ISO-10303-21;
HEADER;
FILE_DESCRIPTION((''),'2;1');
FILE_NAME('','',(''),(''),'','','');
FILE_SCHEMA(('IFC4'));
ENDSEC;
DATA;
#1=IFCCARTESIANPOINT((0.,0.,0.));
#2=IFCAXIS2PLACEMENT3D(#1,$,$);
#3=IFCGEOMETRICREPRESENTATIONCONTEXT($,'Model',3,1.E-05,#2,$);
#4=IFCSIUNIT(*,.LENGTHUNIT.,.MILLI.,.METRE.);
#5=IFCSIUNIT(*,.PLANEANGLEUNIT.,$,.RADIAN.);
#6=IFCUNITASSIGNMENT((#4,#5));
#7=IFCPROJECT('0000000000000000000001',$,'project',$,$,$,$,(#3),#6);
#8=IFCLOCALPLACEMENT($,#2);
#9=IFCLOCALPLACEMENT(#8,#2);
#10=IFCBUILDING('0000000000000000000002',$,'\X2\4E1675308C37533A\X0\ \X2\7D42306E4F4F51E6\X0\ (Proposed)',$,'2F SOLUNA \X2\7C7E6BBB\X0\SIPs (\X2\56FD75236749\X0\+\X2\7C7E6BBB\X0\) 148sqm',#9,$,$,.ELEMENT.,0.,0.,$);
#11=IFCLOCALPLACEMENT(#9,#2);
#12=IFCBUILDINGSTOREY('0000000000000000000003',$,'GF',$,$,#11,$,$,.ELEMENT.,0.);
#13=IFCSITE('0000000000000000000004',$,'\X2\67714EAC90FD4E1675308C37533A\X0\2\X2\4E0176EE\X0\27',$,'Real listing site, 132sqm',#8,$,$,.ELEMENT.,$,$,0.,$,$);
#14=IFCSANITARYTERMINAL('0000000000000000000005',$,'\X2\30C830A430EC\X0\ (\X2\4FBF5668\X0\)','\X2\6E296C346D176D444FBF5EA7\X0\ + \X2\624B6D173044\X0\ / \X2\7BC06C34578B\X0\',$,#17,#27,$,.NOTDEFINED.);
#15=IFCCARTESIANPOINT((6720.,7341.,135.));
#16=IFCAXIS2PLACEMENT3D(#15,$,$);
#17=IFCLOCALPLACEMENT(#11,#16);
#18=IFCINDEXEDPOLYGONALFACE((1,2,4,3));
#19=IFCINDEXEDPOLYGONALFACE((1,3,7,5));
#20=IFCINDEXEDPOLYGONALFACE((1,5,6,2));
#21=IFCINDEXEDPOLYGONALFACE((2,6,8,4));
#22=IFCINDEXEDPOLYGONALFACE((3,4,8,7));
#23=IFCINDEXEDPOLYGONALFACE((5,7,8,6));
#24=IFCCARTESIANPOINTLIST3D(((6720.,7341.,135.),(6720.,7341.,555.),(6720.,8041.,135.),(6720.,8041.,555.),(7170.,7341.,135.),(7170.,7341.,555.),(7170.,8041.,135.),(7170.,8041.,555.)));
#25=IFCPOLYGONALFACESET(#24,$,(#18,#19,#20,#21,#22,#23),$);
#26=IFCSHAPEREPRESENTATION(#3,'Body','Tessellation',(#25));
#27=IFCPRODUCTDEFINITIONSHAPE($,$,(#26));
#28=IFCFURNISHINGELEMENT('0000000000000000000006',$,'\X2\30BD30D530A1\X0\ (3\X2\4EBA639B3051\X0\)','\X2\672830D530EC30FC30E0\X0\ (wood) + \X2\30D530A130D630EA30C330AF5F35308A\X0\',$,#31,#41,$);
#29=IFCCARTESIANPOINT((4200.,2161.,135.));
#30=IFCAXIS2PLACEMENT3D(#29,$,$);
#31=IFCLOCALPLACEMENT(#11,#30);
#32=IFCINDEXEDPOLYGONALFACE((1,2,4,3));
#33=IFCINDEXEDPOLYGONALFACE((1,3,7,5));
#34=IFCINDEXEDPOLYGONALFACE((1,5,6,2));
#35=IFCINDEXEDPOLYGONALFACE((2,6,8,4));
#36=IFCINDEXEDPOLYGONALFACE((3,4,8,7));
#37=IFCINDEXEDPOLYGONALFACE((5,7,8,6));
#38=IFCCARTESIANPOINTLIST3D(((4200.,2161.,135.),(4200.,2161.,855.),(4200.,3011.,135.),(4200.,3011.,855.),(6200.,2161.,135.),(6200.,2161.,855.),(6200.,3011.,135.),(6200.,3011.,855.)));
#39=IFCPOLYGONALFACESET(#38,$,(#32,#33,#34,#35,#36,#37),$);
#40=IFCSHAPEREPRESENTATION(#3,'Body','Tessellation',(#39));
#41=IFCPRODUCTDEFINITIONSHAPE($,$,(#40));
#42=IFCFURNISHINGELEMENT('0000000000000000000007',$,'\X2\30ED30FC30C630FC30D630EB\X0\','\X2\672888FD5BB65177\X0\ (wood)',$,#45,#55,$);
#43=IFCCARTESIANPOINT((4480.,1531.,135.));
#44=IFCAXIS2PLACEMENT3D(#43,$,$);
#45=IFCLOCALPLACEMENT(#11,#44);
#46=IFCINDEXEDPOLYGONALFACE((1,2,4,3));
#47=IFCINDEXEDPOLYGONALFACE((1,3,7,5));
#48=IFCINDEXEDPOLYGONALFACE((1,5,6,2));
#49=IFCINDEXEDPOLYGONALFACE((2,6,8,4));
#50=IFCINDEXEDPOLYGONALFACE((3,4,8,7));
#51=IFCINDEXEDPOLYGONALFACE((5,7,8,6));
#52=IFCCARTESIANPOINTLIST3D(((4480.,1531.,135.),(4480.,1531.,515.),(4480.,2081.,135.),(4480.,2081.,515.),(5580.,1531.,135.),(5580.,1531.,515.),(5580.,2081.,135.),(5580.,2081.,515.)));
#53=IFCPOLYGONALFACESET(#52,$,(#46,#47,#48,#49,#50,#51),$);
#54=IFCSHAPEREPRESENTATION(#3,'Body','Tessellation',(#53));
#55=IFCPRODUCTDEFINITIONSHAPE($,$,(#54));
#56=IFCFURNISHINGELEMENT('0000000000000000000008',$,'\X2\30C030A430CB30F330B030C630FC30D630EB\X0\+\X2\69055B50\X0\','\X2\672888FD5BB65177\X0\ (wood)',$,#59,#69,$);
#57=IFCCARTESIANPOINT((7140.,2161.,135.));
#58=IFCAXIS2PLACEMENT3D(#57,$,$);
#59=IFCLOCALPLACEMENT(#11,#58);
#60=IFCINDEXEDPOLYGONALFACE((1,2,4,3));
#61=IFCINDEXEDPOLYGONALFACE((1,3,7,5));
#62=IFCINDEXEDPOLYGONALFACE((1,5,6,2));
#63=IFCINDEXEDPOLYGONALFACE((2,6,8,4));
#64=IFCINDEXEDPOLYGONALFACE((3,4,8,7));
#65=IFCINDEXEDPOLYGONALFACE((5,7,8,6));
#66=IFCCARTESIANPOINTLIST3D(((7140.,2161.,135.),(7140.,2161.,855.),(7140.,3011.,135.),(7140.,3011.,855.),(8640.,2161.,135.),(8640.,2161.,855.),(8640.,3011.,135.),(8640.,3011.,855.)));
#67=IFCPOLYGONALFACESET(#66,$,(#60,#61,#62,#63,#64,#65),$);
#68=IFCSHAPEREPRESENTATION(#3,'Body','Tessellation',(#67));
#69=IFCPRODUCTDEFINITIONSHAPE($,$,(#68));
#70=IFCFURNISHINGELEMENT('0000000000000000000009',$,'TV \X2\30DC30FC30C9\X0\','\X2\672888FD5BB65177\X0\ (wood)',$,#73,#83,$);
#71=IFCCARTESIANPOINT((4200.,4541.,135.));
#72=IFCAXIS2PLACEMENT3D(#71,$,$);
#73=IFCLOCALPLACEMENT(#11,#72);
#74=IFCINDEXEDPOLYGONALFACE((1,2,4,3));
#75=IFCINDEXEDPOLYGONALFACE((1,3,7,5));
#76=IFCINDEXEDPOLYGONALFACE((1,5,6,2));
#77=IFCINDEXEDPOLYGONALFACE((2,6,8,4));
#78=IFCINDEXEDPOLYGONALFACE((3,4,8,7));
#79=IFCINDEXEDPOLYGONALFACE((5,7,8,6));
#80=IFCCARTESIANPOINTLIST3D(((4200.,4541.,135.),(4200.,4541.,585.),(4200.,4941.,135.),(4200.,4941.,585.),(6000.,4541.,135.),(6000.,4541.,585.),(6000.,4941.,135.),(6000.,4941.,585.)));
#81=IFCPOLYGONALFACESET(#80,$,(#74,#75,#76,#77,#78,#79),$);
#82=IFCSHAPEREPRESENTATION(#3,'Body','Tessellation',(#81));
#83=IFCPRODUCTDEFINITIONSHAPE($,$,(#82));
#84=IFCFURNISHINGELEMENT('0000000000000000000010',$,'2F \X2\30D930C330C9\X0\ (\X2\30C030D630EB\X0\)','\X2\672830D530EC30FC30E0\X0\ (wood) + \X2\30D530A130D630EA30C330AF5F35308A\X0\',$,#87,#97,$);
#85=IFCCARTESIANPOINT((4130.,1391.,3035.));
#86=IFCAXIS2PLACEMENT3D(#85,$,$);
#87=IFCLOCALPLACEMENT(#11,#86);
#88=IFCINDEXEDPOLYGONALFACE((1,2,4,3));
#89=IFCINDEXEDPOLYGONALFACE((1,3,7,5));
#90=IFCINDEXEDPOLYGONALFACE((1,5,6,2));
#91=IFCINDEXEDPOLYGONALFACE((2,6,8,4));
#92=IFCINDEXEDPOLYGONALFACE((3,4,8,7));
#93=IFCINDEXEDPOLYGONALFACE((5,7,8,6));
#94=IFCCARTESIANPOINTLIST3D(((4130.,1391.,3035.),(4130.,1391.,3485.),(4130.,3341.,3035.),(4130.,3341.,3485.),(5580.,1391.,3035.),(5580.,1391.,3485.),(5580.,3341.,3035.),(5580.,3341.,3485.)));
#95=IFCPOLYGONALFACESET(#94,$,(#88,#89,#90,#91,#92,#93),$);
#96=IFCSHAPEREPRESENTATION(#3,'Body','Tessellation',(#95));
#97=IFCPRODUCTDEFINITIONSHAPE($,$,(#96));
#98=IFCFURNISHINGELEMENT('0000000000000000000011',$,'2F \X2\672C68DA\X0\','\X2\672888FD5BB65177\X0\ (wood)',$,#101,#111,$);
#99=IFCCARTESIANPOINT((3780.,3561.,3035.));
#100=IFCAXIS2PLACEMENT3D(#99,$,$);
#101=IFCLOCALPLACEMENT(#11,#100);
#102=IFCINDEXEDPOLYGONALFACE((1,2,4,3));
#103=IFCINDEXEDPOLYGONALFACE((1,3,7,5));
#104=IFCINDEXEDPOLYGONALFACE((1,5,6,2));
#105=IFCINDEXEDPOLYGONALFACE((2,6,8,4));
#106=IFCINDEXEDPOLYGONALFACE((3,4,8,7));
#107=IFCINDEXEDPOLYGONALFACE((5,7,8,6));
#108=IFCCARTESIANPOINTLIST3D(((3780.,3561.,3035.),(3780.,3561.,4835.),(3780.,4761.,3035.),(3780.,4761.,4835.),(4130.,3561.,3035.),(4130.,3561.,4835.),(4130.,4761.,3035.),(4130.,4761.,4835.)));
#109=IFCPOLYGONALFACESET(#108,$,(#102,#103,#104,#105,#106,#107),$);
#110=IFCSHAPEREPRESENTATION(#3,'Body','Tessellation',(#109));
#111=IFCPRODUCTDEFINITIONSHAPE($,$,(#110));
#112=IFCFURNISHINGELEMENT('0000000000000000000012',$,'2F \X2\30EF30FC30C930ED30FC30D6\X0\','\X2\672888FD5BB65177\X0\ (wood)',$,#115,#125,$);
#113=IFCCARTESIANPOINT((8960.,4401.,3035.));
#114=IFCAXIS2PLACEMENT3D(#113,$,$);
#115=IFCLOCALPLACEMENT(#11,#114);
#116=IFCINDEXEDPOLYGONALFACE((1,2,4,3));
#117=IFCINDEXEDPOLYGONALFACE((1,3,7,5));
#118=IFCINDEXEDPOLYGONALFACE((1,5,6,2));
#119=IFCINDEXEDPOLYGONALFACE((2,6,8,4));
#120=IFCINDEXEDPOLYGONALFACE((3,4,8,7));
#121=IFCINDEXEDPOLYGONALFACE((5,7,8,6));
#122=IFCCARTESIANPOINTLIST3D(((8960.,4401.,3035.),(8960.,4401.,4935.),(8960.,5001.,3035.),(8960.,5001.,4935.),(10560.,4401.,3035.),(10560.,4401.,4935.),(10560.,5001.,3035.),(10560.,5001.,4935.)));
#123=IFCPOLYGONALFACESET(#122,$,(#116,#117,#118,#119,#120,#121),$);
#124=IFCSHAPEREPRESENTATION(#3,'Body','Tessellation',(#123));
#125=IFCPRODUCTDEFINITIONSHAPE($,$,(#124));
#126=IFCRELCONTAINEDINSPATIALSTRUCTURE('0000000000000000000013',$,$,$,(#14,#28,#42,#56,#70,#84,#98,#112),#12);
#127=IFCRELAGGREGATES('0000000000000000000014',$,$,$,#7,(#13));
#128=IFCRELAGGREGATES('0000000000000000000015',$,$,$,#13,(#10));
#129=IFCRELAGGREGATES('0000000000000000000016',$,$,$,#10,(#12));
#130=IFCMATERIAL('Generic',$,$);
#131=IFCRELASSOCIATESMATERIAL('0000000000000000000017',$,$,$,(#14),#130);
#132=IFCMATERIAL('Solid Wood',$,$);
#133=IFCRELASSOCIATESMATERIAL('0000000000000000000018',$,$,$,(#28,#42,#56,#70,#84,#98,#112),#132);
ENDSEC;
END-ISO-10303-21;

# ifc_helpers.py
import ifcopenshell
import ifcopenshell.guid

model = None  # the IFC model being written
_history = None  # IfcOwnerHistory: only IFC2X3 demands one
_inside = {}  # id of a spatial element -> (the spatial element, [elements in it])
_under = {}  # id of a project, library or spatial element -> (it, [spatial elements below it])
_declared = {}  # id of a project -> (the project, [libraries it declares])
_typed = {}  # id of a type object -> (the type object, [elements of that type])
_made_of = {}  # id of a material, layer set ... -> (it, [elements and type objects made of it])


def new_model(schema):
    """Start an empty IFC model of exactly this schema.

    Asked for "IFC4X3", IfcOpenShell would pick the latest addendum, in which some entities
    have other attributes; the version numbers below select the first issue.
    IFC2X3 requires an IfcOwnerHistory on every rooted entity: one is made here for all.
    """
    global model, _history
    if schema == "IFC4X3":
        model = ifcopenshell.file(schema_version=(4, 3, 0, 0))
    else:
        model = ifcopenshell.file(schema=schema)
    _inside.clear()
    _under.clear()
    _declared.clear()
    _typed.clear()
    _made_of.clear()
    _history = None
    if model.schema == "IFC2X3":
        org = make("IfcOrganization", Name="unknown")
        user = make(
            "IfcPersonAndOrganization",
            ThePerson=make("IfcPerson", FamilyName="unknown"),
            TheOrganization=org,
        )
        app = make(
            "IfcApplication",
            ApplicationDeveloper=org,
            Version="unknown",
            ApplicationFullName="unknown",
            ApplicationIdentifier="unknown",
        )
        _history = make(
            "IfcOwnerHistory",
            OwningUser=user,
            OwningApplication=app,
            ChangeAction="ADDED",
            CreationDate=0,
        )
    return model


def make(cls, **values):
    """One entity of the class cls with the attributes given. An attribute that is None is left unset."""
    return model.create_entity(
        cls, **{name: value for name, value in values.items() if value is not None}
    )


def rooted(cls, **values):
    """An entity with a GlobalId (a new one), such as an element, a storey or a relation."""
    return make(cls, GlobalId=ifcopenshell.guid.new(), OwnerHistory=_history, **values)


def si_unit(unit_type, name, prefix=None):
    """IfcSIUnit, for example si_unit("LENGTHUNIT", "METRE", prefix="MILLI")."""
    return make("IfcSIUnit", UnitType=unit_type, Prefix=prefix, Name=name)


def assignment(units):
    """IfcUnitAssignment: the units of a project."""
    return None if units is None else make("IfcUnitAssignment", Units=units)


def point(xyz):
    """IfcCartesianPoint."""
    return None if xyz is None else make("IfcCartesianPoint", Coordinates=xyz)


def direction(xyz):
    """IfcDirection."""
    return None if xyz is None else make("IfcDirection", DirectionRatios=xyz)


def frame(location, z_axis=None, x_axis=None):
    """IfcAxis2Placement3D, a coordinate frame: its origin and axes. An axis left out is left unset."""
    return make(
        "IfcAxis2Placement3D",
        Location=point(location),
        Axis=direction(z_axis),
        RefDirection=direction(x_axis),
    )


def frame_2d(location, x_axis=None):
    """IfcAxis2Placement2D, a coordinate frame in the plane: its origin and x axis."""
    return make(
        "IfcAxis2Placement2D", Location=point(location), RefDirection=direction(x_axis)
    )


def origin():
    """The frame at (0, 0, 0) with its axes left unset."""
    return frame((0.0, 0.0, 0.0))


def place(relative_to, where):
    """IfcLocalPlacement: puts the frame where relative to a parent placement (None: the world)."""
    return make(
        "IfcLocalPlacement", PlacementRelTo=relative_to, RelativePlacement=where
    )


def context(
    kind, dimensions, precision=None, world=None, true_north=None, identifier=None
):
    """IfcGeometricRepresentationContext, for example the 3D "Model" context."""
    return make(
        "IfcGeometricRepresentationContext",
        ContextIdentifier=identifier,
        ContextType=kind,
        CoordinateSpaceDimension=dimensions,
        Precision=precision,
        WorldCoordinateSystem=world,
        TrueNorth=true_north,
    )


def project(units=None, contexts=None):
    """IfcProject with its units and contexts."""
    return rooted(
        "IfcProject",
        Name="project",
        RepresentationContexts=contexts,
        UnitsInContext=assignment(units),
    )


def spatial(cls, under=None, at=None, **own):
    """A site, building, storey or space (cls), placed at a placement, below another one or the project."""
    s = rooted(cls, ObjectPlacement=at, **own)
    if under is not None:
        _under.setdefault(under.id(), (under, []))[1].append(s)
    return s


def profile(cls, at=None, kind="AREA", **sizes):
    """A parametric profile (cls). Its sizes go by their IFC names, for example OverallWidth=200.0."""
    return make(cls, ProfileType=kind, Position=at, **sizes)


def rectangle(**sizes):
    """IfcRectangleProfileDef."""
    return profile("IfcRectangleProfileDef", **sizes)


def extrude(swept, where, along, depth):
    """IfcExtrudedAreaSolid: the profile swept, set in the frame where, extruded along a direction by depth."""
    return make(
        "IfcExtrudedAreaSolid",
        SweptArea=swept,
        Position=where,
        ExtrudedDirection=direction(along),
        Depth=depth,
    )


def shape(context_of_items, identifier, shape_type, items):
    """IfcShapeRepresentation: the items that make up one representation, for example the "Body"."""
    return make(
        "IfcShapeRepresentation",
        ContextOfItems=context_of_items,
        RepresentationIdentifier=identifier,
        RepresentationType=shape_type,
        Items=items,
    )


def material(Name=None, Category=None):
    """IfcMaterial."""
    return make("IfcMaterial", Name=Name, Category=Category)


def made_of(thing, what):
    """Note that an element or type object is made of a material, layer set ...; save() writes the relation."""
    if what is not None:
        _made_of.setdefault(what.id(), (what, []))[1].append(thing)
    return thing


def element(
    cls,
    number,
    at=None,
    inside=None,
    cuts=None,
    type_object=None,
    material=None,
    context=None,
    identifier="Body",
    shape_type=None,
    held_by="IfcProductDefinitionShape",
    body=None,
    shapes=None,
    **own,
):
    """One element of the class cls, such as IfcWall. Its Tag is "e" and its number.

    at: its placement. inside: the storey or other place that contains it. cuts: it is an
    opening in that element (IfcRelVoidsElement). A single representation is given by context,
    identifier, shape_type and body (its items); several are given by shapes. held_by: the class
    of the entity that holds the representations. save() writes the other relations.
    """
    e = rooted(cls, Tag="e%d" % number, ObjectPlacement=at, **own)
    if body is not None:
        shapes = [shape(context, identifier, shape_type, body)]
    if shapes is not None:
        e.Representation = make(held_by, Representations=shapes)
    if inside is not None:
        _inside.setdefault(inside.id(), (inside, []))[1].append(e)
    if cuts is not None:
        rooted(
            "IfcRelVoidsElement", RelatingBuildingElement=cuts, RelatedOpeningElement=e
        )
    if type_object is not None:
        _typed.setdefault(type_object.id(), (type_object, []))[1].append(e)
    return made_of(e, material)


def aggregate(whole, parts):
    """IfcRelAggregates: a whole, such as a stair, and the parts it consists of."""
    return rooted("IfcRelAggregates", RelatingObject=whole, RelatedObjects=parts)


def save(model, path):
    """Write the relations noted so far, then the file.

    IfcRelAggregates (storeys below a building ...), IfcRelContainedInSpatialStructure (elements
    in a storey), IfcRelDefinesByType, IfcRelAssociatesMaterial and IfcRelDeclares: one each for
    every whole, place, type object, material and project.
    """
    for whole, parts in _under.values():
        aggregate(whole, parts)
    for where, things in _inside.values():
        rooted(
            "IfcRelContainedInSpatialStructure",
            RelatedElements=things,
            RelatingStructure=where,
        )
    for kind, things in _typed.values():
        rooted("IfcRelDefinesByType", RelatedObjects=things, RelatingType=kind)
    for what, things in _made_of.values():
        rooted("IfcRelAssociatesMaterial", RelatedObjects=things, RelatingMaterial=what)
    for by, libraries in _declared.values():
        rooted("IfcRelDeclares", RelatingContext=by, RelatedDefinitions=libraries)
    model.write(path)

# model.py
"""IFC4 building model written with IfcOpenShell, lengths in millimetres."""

from ifc_helpers import new_model, si_unit, frame, frame_2d, origin, place, context, project, spatial, rectangle, extrude, material, element, save


model = new_model("IFC4")

# Units and contexts
model_context = context("Model", 3, precision=1e-05, world=origin())
ifc_project = project(units=[si_unit("LENGTHUNIT", "METRE", prefix="MILLI"), si_unit("PLANEANGLEUNIT", "RADIAN")], contexts=[model_context])

# Site, building, storey
site_placement = place(None, origin())
site = spatial("IfcSite", under=ifc_project, at=site_placement, Name="東京都世田谷区2丁目27", ObjectType="Real listing site, 132sqm", CompositionType="ELEMENT", RefElevation=0.0)
building_placement = place(site_placement, origin())
building = spatial("IfcBuilding", under=site, at=building_placement, Name="世田谷区 終の住処 (Proposed)", ObjectType="2F SOLUNA 籾殻SIPs (国産杉+籾殻) 148sqm", CompositionType="ELEMENT", ElevationOfRefHeight=0.0, ElevationOfTerrain=0.0)
storey_placement = place(building_placement, origin())
storey = spatial("IfcBuildingStorey", under=building, at=storey_placement, Name="GF", CompositionType="ELEMENT", Elevation=0.0)

# Shared definitions
ifc_material_1 = material(Name="Solid Wood")

# Shared definitions
ifc_material_2 = material(Name="Generic")

# Sanitary terminal
sanitary_terminal_1_placement = place(storey_placement, frame((6720.0, 7341.0, 135.0)))
element("IfcSanitaryTerminal", 1, at=sanitary_terminal_1_placement, inside=storey, material=ifc_material_2, Name="トイレ (便器)", Description="温水洗浄便座 + 手洗い / 節水型", PredefinedType="NOTDEFINED", context=model_context, shape_type="SweptSolid", body=[
    extrude(rectangle(XDim=450.0, YDim=700.0, at=frame_2d((225.0, 350.0))), frame((6720.0, 7341.0, 135.0)), (0.0, 0.0, 1.0), 420.0),
])

# Furnishing elements
furnishing_1_placement = place(storey_placement, frame((4200.0, 2161.0, 135.0)))
element("IfcFurnishingElement", 2, at=furnishing_1_placement, inside=storey, material=ifc_material_1, Name="ソファ (3人掛け)", Description="木フレーム (wood) + ファブリック張り", context=model_context, shape_type="SweptSolid", body=[
    extrude(rectangle(XDim=2000.0, YDim=850.0, at=frame_2d((1000.0, 425.0))), frame((4200.0, 2161.0, 135.0)), (0.0, 0.0, 1.0), 720.0),
])
furnishing_2_placement = place(storey_placement, frame((4480.0, 1531.0, 135.0)))
element("IfcFurnishingElement", 3, at=furnishing_2_placement, inside=storey, material=ifc_material_1, Name="ローテーブル", Description="木製家具 (wood)", context=model_context, shape_type="SweptSolid", body=[
    extrude(rectangle(XDim=1100.0, YDim=550.0, at=frame_2d((550.0, 275.0))), frame((4480.0, 1531.0, 135.0)), (0.0, 0.0, 1.0), 380.0),
])
furnishing_3_placement = place(storey_placement, frame((7140.0, 2161.0, 135.0)))
element("IfcFurnishingElement", 4, at=furnishing_3_placement, inside=storey, material=ifc_material_1, Name="ダイニングテーブル+椅子", Description="木製家具 (wood)", context=model_context, shape_type="SweptSolid", body=[
    extrude(rectangle(XDim=1500.0, YDim=850.0, at=frame_2d((750.0, 425.0))), frame((7140.0, 2161.0, 135.0)), (0.0, 0.0, 1.0), 720.0),
])
furnishing_4_placement = place(storey_placement, frame((4200.0, 4541.0, 135.0)))
element("IfcFurnishingElement", 5, at=furnishing_4_placement, inside=storey, material=ifc_material_1, Name="TV ボード", Description="木製家具 (wood)", context=model_context, shape_type="SweptSolid", body=[
    extrude(rectangle(XDim=1800.0, YDim=400.0, at=frame_2d((900.0, 200.0))), frame((4200.0, 4541.0, 135.0)), (0.0, 0.0, 1.0), 450.0),
])
furnishing_5_placement = place(storey_placement, frame((4130.0, 1391.0, 3035.0)))
element("IfcFurnishingElement", 6, at=furnishing_5_placement, inside=storey, material=ifc_material_1, Name="2F ベッド (ダブル)", Description="木フレーム (wood) + ファブリック張り", context=model_context, shape_type="SweptSolid", body=[
    extrude(rectangle(XDim=1450.0, YDim=1950.0, at=frame_2d((725.0, 975.0))), frame((4130.0, 1391.0, 3035.0)), (0.0, 0.0, 1.0), 450.0),
])
furnishing_6_placement = place(storey_placement, frame((3780.0, 3561.0, 3035.0)))
element("IfcFurnishingElement", 7, at=furnishing_6_placement, inside=storey, material=ifc_material_1, Name="2F 本棚", Description="木製家具 (wood)", context=model_context, shape_type="SweptSolid", body=[
    extrude(rectangle(XDim=350.0, YDim=1200.0, at=frame_2d((175.0, 600.0))), frame((3780.0, 3561.0, 3035.0)), (0.0, 0.0, 1.0), 1800.0),
])
furnishing_7_placement = place(storey_placement, frame((8960.0, 4401.0, 3035.0)))
element("IfcFurnishingElement", 8, at=furnishing_7_placement, inside=storey, material=ifc_material_1, Name="2F ワードローブ", Description="木製家具 (wood)", context=model_context, shape_type="SweptSolid", body=[
    extrude(rectangle(XDim=1600.0, YDim=600.0, at=frame_2d((800.0, 300.0))), frame((8960.0, 4401.0, 3035.0)), (0.0, 0.0, 1.0), 1900.0),
])

save(model, "model.ifc")
